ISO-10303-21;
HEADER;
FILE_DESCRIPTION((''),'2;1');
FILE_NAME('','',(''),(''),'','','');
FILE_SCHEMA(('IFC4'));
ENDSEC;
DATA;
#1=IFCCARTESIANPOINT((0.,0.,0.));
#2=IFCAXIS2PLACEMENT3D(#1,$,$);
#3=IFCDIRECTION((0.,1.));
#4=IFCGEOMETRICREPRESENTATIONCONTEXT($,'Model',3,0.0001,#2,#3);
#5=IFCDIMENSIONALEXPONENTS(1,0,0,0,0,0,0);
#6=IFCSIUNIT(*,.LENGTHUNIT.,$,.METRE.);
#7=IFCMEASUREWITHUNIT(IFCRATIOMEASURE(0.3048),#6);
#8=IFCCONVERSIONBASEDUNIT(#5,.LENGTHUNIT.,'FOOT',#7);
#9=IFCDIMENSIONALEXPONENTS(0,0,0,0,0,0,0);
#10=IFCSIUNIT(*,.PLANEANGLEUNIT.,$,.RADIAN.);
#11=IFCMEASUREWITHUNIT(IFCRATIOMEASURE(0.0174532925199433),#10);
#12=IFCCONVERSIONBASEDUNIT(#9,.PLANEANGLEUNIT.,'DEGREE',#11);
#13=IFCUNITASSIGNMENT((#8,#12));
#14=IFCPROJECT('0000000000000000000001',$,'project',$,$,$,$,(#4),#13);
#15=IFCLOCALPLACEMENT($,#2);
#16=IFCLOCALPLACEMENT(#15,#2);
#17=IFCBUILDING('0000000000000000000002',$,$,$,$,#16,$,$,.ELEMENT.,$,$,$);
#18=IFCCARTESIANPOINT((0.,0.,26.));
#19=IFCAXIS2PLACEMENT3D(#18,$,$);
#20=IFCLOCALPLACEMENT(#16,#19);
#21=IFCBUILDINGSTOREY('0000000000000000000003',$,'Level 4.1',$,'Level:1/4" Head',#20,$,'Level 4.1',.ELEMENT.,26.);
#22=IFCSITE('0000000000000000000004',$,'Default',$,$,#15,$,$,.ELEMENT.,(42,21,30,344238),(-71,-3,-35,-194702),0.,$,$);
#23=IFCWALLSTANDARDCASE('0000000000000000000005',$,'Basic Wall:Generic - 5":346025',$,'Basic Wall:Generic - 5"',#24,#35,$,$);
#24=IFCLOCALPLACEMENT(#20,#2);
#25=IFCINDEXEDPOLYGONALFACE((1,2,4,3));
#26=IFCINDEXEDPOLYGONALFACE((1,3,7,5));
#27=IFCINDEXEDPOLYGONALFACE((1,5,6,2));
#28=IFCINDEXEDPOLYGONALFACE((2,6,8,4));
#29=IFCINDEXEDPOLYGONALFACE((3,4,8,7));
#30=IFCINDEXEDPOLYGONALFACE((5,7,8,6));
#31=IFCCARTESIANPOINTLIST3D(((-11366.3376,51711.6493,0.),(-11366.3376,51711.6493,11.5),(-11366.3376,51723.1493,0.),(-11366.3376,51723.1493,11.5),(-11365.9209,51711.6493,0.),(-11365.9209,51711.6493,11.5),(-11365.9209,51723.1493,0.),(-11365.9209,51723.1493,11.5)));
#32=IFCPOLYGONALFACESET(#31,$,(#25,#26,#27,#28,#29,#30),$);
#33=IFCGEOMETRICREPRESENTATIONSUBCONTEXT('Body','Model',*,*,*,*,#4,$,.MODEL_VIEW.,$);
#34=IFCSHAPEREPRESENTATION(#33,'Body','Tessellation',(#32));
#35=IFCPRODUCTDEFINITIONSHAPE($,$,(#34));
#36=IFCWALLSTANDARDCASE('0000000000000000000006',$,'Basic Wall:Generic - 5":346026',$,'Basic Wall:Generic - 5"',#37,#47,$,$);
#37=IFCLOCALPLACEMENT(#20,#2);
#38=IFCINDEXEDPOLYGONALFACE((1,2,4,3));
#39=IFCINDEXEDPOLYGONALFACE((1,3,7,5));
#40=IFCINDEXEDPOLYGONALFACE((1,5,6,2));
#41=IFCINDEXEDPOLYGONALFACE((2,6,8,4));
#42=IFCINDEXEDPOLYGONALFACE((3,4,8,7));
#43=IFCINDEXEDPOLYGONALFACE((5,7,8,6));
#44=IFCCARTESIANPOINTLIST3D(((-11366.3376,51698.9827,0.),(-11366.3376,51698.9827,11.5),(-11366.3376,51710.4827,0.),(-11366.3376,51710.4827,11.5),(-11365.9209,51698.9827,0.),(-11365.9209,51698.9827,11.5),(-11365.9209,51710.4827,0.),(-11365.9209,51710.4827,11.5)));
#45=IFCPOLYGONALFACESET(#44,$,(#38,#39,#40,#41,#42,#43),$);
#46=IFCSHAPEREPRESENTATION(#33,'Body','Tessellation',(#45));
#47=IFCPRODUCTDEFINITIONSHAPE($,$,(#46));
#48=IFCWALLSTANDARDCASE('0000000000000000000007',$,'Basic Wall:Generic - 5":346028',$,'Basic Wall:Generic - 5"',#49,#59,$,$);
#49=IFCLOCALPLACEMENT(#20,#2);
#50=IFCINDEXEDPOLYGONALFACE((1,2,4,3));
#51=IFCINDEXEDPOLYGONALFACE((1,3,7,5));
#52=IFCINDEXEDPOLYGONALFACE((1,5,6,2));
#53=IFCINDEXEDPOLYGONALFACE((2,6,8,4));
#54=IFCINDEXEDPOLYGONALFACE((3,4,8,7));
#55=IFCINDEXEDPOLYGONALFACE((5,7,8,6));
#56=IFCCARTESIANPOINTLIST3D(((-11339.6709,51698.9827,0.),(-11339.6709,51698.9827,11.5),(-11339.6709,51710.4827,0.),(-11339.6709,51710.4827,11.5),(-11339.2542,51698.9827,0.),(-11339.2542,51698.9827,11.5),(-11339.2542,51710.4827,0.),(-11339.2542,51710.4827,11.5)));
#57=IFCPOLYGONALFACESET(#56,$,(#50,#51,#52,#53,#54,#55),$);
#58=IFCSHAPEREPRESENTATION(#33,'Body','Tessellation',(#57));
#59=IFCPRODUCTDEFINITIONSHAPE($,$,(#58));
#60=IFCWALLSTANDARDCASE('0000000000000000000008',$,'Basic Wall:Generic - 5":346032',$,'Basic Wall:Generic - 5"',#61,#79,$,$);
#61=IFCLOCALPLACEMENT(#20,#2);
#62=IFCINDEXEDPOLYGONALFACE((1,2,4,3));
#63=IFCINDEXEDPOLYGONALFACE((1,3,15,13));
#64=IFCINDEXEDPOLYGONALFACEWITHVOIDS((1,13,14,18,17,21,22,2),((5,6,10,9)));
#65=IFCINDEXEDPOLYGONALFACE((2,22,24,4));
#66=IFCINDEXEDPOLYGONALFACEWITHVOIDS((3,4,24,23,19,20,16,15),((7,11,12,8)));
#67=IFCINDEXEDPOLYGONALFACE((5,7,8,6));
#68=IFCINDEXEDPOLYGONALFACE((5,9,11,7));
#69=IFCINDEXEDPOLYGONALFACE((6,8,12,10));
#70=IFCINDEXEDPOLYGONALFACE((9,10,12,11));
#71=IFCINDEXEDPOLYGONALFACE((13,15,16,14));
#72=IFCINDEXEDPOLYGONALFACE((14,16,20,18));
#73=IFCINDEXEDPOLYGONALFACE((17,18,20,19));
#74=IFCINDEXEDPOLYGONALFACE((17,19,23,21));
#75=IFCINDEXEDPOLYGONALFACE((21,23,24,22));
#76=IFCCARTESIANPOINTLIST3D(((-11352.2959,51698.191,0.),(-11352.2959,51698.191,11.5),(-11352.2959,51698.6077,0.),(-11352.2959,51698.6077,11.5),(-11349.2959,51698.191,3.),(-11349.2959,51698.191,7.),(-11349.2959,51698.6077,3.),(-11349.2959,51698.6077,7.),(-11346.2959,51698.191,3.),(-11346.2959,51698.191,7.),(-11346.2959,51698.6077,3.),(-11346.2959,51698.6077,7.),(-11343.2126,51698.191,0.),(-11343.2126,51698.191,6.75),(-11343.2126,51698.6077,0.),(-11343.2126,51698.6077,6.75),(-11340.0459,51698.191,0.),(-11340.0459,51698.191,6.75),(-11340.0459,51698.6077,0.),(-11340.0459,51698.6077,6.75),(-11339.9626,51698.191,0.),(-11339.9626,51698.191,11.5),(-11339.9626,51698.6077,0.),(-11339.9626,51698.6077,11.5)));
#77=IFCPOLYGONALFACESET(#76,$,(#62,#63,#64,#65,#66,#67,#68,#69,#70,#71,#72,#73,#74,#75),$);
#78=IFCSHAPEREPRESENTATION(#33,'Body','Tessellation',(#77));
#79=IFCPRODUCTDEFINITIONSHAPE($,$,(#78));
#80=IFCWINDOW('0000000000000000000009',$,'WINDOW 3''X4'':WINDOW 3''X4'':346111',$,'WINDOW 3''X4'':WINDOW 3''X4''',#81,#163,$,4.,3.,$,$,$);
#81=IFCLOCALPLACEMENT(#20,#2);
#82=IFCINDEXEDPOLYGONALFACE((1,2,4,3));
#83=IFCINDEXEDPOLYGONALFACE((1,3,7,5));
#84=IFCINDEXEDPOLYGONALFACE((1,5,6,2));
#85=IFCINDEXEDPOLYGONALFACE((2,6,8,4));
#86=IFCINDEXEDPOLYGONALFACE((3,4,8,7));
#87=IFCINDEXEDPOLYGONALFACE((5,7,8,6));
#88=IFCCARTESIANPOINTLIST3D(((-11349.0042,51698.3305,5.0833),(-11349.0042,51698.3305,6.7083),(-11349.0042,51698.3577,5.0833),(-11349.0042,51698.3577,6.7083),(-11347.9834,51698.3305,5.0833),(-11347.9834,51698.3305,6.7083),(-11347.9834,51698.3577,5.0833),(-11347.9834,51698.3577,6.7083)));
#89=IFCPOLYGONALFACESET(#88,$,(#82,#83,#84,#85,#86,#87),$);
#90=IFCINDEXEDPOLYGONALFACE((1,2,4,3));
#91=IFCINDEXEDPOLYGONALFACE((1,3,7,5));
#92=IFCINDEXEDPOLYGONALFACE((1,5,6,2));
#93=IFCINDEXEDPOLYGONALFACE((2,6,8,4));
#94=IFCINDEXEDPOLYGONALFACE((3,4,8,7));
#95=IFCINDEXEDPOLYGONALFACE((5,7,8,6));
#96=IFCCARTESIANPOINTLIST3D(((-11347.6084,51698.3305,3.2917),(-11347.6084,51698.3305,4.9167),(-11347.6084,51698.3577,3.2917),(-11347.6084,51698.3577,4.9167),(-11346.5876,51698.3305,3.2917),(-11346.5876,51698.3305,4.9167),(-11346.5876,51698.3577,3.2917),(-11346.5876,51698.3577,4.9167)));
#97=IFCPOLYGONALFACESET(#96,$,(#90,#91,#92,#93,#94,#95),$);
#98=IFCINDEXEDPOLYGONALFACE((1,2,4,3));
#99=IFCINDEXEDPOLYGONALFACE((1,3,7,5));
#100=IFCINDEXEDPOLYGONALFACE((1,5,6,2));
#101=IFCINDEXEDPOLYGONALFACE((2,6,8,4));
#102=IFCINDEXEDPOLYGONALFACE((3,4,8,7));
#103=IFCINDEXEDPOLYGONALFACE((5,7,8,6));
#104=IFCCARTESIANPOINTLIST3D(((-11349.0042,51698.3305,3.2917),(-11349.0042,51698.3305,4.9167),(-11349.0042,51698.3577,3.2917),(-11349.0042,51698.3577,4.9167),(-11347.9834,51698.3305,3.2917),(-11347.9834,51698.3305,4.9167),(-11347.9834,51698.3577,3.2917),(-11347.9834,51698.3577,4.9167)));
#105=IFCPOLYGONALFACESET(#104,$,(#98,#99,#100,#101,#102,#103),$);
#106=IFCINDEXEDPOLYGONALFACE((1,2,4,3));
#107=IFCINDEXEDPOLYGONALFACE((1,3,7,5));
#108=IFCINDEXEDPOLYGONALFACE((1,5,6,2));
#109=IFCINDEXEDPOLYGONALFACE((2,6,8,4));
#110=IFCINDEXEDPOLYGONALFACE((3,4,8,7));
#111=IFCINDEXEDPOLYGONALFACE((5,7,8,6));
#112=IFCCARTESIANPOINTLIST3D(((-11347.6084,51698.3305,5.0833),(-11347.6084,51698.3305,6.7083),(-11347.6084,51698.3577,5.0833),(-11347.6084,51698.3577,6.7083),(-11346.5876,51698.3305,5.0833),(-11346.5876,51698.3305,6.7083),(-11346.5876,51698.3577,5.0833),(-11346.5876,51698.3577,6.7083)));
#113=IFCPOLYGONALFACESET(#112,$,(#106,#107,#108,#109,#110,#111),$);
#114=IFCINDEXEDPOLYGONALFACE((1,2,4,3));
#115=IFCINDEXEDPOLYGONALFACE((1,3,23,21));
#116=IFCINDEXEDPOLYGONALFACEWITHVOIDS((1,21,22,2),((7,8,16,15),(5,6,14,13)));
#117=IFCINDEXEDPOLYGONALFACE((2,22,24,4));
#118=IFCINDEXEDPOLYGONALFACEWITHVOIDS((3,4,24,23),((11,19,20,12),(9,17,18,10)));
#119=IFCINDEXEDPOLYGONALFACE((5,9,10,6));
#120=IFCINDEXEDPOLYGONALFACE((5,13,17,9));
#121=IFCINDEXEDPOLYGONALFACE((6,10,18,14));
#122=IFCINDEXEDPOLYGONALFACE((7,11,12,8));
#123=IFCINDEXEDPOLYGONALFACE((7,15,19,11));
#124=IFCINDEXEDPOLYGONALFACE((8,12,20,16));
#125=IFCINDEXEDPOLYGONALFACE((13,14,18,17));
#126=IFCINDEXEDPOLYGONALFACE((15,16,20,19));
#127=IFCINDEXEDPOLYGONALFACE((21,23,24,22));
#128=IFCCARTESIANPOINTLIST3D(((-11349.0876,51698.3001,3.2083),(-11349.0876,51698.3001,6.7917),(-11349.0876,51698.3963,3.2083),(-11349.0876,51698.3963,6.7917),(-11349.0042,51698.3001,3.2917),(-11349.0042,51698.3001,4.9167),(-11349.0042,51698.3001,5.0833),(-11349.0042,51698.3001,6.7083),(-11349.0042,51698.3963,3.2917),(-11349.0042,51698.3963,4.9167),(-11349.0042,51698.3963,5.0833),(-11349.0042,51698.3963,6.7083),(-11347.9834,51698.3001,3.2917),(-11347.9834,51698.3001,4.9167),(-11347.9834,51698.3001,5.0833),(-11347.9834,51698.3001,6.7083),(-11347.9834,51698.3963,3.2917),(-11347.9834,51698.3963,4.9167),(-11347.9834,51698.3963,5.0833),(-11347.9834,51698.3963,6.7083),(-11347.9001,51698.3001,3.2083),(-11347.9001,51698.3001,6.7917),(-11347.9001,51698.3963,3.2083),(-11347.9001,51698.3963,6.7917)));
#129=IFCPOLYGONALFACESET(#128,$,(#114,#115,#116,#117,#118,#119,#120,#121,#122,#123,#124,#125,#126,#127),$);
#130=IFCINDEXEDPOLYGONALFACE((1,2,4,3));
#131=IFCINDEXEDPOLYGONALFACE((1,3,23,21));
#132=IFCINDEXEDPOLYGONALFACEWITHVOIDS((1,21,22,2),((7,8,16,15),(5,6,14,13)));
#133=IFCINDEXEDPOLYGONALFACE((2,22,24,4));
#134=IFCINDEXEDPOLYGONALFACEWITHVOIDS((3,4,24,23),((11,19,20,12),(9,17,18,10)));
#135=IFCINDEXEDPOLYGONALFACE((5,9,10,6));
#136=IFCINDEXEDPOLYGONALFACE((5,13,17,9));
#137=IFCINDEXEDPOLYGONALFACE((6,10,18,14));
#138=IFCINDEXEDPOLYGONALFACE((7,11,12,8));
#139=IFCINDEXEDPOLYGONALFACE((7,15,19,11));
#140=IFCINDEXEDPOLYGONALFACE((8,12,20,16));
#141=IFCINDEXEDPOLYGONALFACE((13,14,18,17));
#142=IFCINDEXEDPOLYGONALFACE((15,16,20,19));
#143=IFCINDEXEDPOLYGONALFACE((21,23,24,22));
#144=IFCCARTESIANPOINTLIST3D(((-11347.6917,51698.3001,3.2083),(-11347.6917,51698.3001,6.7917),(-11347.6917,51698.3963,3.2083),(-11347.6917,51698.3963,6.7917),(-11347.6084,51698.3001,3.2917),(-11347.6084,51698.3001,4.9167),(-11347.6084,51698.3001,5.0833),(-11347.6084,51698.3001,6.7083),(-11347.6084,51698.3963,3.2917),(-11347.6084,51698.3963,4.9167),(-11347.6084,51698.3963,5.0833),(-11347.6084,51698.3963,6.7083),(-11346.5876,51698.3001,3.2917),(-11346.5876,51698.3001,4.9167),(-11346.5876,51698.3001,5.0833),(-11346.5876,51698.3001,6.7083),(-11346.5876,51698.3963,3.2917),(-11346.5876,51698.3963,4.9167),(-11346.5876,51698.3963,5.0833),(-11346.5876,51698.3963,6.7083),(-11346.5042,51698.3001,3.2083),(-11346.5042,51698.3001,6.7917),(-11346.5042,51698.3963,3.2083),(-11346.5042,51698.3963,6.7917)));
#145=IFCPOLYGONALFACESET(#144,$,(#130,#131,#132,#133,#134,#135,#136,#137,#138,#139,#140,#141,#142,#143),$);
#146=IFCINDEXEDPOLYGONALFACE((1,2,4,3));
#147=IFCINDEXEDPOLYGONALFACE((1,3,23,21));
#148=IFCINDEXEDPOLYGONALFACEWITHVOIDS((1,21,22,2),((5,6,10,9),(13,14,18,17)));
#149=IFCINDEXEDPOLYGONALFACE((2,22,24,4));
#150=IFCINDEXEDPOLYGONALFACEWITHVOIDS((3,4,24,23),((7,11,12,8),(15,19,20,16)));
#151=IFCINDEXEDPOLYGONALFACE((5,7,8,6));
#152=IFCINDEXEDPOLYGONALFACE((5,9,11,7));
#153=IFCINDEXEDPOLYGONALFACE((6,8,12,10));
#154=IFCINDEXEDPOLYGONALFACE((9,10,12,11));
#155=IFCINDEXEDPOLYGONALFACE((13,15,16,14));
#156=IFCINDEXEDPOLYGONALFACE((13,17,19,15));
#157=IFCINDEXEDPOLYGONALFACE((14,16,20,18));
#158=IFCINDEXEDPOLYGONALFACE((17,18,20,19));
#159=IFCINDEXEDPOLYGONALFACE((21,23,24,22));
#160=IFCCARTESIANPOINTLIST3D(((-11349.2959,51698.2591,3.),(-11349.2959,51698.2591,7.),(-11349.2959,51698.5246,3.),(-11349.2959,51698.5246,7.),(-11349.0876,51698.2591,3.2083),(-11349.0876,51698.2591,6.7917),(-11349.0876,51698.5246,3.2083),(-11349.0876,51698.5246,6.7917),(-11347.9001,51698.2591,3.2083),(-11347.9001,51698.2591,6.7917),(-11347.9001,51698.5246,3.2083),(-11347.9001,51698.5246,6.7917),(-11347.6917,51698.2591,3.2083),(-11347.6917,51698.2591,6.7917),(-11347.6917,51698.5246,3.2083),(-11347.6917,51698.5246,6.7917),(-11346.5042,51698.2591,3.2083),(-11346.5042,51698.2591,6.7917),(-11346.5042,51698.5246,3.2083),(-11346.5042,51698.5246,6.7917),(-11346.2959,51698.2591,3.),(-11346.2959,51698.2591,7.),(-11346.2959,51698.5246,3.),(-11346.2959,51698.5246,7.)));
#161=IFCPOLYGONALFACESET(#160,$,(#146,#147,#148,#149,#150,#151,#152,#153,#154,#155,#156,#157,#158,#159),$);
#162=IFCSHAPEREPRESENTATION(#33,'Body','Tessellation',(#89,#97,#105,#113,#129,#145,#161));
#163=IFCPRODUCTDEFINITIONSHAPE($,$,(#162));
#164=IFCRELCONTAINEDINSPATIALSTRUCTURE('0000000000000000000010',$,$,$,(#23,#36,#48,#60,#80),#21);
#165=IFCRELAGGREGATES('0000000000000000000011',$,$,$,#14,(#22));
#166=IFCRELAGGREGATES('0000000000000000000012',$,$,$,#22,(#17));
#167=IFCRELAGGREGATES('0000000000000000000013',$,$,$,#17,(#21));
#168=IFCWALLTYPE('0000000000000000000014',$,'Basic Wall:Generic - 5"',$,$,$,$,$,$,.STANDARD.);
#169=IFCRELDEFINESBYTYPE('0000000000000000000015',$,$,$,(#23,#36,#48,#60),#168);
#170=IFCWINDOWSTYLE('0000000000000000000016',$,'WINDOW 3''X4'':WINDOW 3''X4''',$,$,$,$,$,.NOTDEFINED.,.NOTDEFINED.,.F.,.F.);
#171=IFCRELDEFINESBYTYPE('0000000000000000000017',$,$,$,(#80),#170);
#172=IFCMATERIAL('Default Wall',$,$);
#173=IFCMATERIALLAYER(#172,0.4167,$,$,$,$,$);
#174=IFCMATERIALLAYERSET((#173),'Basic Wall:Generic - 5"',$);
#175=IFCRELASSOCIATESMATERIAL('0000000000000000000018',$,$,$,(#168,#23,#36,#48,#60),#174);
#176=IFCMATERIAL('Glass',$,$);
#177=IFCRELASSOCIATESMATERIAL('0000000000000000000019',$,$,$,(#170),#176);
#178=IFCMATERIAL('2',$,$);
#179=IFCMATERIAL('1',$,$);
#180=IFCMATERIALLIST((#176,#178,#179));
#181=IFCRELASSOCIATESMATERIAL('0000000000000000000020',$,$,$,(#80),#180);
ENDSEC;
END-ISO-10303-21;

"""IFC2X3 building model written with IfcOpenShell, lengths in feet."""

from ifc_helpers import new_model, entity, si_unit, converted_unit, direction, frame, frame_2d, origin, origin_2d_with_axis, place, context, subcontext, project, spatial, polyline, rectangle, outline, extrude, source, transform, mapped, material, material_list, layer, layer_set, layer_usage, type_object, type_shapes, element, fill, save


model = new_model("IFC2X3")

# Units and contexts
model_context = context("Model", 3, precision=0.0001, world=origin(), true_north=direction((0.0, 1.0)))
body_context = subcontext(model_context, "Body", "Model", "MODEL_VIEW")
ifc_project = project(units=[converted_unit("LENGTHUNIT", "FOOT", entity("IfcRatioMeasure", 0.3048), si_unit("LENGTHUNIT", "METRE"), dimensions=[1, 0, 0, 0, 0, 0, 0]), converted_unit("PLANEANGLEUNIT", "DEGREE", entity("IfcRatioMeasure", 0.0174532925199433), si_unit("PLANEANGLEUNIT", "RADIAN"), dimensions=[0, 0, 0, 0, 0, 0, 0])], contexts=[model_context])

# Site, building, storey
site_placement = place(None, origin())
site = spatial("IfcSite", under=ifc_project, at=site_placement, Name="Default", CompositionType="ELEMENT", RefLatitude=(42, 21, 30, 344238), RefLongitude=(-71, -3, -35, -194702), RefElevation=0.0)
building_placement = place(site_placement, origin())
building = spatial("IfcBuilding", under=site, at=building_placement, CompositionType="ELEMENT")
storey_placement = place(building_placement, frame((0.0, 0.0, 26.0)))
storey = spatial("IfcBuildingStorey", under=building, at=storey_placement, Name="Level 4.1", ObjectType="Level:1/4\" Head", LongName="Level 4.1", CompositionType="ELEMENT", Elevation=26.0)

# Shared definitions
ifc_material_1 = material(Name="Default Wall")
ifc_material_2 = material(Name="Glass")
ifc_material_3 = material(Name="2")
ifc_material_4 = material(Name="1")
ifc_layer_1 = layer(ifc_material_1, 0.4167)
ifc_layer_set_1 = layer_set([ifc_layer_1], Name="Basic Wall:Generic - 5\"")
wall_type_1 = type_object("IfcWallType", Name="Basic Wall:Generic - 5\"", PredefinedType="STANDARD", material=ifc_layer_set_1)

# Walls
ifc_layer_usage_1 = layer_usage(ifc_layer_set_1, "AXIS2", "NEGATIVE", 0.2083)
wall_1_placement = place(storey_placement, frame((-11366.1292, 51723.1493, 0.0), z_axis=(0.0, 0.0, 1.0), x_axis=(0.0, -1.0, 0.0)))
element("IfcWallStandardCase", 1, at=wall_1_placement, inside=storey, type_object=wall_type_1, material=ifc_layer_usage_1, Name="Basic Wall:Generic - 5\":346025", ObjectType="Basic Wall:Generic - 5\"", context=body_context, shape_type="SweptSolid", body=[
    extrude(rectangle(XDim=11.5, YDim=0.4167, at=frame_2d((5.75, 0.0), x_axis=(-1.0, 0.0))), origin(), (0.0, 0.0, 1.0), 11.5),
])
ifc_layer_usage_2 = layer_usage(ifc_layer_set_1, "AXIS2", "NEGATIVE", 0.2083)
wall_2_placement = place(storey_placement, frame((-11366.1292, 51710.4827, 0.0), z_axis=(0.0, 0.0, 1.0), x_axis=(0.0, -1.0, 0.0)))
element("IfcWallStandardCase", 2, at=wall_2_placement, inside=storey, type_object=wall_type_1, material=ifc_layer_usage_2, Name="Basic Wall:Generic - 5\":346026", ObjectType="Basic Wall:Generic - 5\"", context=body_context, shape_type="SweptSolid", body=[
    extrude(rectangle(XDim=11.5, YDim=0.4167, at=frame_2d((5.75, 0.0), x_axis=(-1.0, 0.0))), origin(), (0.0, 0.0, 1.0), 11.5),
])
ifc_layer_usage_3 = layer_usage(ifc_layer_set_1, "AXIS2", "NEGATIVE", 0.2083)
wall_3_placement = place(storey_placement, frame((-11339.4626, 51710.4827, 0.0), z_axis=(0.0, 0.0, 1.0), x_axis=(0.0, -1.0, 0.0)))
element("IfcWallStandardCase", 3, at=wall_3_placement, inside=storey, type_object=wall_type_1, material=ifc_layer_usage_3, Name="Basic Wall:Generic - 5\":346028", ObjectType="Basic Wall:Generic - 5\"", context=body_context, shape_type="SweptSolid", body=[
    extrude(rectangle(XDim=11.5, YDim=0.4167, at=frame_2d((5.75, 0.0), x_axis=(-1.0, 0.0))), origin(), (0.0, 0.0, 1.0), 11.5),
])

# Wall, openings, window
ifc_layer_usage_4 = layer_usage(ifc_layer_set_1, "AXIS2", "NEGATIVE", 0.2083)
wall_4_placement = place(storey_placement, frame((-11352.2959, 51698.3993, 0.0)))
wall_4 = element("IfcWallStandardCase", 4, at=wall_4_placement, inside=storey, type_object=wall_type_1, material=ifc_layer_usage_4, Name="Basic Wall:Generic - 5\":346032", ObjectType="Basic Wall:Generic - 5\"", context=body_context, shape_type="SweptSolid", body=[
    extrude(rectangle(XDim=12.3333, YDim=0.4167, at=frame_2d((6.1667, 0.0), x_axis=(-1.0, 0.0))), origin(), (0.0, 0.0, 1.0), 11.5),
])
opening_1_placement = place(wall_4_placement, frame((9.0833, -0.2083, 0.0)))
element("IfcOpeningElement", 5, at=opening_1_placement, cuts=wall_4, ObjectType="Opening", context=body_context, shape_type="SweptSolid", body=[
    extrude(rectangle(XDim=6.75, YDim=3.1667, at=frame_2d((3.375, 1.5833), x_axis=(1.0, 0.0))), frame((0.0, 0.0, 0.0), z_axis=(0.0, 1.0, 0.0), x_axis=(0.0, 0.0, 1.0)), (0.0, 0.0, 1.0), 0.4167),
])
opening_2_placement = place(wall_4_placement, frame((6.0, 0.2083, 3.0)))
opening_2 = element("IfcOpeningElement", 6, at=opening_2_placement, cuts=wall_4, ObjectType="Opening", context=body_context, shape_type="SweptSolid", body=[
    extrude(rectangle(XDim=4.0, YDim=3.0, at=frame_2d((2.0, 1.5), x_axis=(-1.0, 0.0))), frame((0.0, 0.0, 0.0), z_axis=(0.0, -1.0, 0.0), x_axis=(0.0, 0.0, 1.0)), (0.0, 0.0, 1.0), 0.4167),
])
ifc_material_list_1 = material_list([ifc_material_2, ifc_material_3, ifc_material_4])
window_style_1 = type_object("IfcWindowStyle", Name="WINDOW 3'X4':WINDOW 3'X4'", ConstructionType="NOTDEFINED", OperationType="NOTDEFINED", ParameterTakesPrecedence=False, Sizeable=False, material=ifc_material_2)
shared_shape_1 = source(origin(), body_context, "Body", "SweptSolid", [
    extrude(rectangle(XDim=0.0272, YDim=1.0208, at=origin_2d_with_axis()), frame((2.1979, 0.2636, 2.0833), z_axis=(0.0, 0.0, 1.0), x_axis=(0.0, 1.0, 0.0)), (0.0, 0.0, 1.0), 1.625),
    extrude(rectangle(XDim=0.0272, YDim=1.0208, at=origin_2d_with_axis()), frame((0.8021, 0.2636, 0.2917), z_axis=(0.0, 0.0, 1.0), x_axis=(0.0, 1.0, 0.0)), (0.0, 0.0, 1.0), 1.625),
    extrude(rectangle(XDim=0.0272, YDim=1.0208, at=origin_2d_with_axis()), frame((2.1979, 0.2636, 0.2917), z_axis=(0.0, 0.0, 1.0), x_axis=(0.0, 1.0, 0.0)), (0.0, 0.0, 1.0), 1.625),
    extrude(rectangle(XDim=0.0272, YDim=1.0208, at=origin_2d_with_axis()), frame((0.8021, 0.2636, 2.0833), z_axis=(0.0, 0.0, 1.0), x_axis=(0.0, 1.0, 0.0)), (0.0, 0.0, 1.0), 1.625),
    extrude(outline(polyline([(-0.5938, -1.7917), (0.5938, -1.7917), (0.5938, 1.7917), (-0.5938, 1.7917), (-0.5938, -1.7917)]), holes=[polyline([(-0.5104, -0.0833), (0.5104, -0.0833), (0.5104, -1.7083), (-0.5104, -1.7083), (-0.5104, -0.0833)]), polyline([(-0.5104, 1.7083), (0.5104, 1.7083), (0.5104, 0.0833), (-0.5104, 0.0833), (-0.5104, 1.7083)])]), frame((2.1979, 0.2114, 2.0), z_axis=(0.0, 1.0, 0.0), x_axis=(-1.0, 0.0, 0.0)), (0.0, 0.0, 1.0), 0.0962),
    extrude(outline(polyline([(-1.7917, -0.5937), (1.7917, -0.5937), (1.7917, 0.5937), (-1.7917, 0.5937), (-1.7917, -0.5937)]), holes=[polyline([(0.0833, -0.5104), (0.0833, 0.5104), (1.7083, 0.5104), (1.7083, -0.5104), (0.0833, -0.5104)]), polyline([(-1.7083, -0.5104), (-1.7083, 0.5104), (-0.0833, 0.5104), (-0.0833, -0.5104), (-1.7083, -0.5104)])]), frame((0.8021, 0.2114, 2.0), z_axis=(0.0, 1.0, 0.0), x_axis=(0.0, 0.0, -1.0)), (0.0, 0.0, 1.0), 0.0962),
    extrude(outline(polyline([(-1.5, -2.0), (1.5, -2.0), (1.5, 2.0), (-1.5, 2.0), (-1.5, -2.0)]), holes=[polyline([(-0.1042, 1.7917), (-0.1042, -1.7917), (-1.2917, -1.7917), (-1.2917, 1.7917), (-0.1042, 1.7917)]), polyline([(0.1042, -1.7917), (0.1042, 1.7917), (1.2917, 1.7917), (1.2917, -1.7917), (0.1042, -1.7917)])]), frame((1.5, 0.0831, 2.0), z_axis=(0.0, 1.0, 0.0), x_axis=(1.0, 0.0, 0.0)), (0.0, 0.0, 1.0), 0.2655),
])
type_shapes(window_style_1, [shared_shape_1])
window_1_placement = place(opening_2_placement, frame((0.0, 0.0, 0.0), z_axis=(0.0, 0.0, 1.0), x_axis=(-1.0, 0.0, 0.0)))
window_1 = element("IfcWindow", 7, at=window_1_placement, inside=storey, type_object=window_style_1, material=ifc_material_list_1, Name="WINDOW 3'X4':WINDOW 3'X4':346111", ObjectType="WINDOW 3'X4':WINDOW 3'X4'", OverallHeight=4.0, OverallWidth=3.0, context=body_context, shape_type="MappedRepresentation", body=[
    mapped(shared_shape_1, transform((0.0, 0.0, 0.0), scale=1.0)),
])
fill(opening_2, window_1)

save(model, "model.ifc")
